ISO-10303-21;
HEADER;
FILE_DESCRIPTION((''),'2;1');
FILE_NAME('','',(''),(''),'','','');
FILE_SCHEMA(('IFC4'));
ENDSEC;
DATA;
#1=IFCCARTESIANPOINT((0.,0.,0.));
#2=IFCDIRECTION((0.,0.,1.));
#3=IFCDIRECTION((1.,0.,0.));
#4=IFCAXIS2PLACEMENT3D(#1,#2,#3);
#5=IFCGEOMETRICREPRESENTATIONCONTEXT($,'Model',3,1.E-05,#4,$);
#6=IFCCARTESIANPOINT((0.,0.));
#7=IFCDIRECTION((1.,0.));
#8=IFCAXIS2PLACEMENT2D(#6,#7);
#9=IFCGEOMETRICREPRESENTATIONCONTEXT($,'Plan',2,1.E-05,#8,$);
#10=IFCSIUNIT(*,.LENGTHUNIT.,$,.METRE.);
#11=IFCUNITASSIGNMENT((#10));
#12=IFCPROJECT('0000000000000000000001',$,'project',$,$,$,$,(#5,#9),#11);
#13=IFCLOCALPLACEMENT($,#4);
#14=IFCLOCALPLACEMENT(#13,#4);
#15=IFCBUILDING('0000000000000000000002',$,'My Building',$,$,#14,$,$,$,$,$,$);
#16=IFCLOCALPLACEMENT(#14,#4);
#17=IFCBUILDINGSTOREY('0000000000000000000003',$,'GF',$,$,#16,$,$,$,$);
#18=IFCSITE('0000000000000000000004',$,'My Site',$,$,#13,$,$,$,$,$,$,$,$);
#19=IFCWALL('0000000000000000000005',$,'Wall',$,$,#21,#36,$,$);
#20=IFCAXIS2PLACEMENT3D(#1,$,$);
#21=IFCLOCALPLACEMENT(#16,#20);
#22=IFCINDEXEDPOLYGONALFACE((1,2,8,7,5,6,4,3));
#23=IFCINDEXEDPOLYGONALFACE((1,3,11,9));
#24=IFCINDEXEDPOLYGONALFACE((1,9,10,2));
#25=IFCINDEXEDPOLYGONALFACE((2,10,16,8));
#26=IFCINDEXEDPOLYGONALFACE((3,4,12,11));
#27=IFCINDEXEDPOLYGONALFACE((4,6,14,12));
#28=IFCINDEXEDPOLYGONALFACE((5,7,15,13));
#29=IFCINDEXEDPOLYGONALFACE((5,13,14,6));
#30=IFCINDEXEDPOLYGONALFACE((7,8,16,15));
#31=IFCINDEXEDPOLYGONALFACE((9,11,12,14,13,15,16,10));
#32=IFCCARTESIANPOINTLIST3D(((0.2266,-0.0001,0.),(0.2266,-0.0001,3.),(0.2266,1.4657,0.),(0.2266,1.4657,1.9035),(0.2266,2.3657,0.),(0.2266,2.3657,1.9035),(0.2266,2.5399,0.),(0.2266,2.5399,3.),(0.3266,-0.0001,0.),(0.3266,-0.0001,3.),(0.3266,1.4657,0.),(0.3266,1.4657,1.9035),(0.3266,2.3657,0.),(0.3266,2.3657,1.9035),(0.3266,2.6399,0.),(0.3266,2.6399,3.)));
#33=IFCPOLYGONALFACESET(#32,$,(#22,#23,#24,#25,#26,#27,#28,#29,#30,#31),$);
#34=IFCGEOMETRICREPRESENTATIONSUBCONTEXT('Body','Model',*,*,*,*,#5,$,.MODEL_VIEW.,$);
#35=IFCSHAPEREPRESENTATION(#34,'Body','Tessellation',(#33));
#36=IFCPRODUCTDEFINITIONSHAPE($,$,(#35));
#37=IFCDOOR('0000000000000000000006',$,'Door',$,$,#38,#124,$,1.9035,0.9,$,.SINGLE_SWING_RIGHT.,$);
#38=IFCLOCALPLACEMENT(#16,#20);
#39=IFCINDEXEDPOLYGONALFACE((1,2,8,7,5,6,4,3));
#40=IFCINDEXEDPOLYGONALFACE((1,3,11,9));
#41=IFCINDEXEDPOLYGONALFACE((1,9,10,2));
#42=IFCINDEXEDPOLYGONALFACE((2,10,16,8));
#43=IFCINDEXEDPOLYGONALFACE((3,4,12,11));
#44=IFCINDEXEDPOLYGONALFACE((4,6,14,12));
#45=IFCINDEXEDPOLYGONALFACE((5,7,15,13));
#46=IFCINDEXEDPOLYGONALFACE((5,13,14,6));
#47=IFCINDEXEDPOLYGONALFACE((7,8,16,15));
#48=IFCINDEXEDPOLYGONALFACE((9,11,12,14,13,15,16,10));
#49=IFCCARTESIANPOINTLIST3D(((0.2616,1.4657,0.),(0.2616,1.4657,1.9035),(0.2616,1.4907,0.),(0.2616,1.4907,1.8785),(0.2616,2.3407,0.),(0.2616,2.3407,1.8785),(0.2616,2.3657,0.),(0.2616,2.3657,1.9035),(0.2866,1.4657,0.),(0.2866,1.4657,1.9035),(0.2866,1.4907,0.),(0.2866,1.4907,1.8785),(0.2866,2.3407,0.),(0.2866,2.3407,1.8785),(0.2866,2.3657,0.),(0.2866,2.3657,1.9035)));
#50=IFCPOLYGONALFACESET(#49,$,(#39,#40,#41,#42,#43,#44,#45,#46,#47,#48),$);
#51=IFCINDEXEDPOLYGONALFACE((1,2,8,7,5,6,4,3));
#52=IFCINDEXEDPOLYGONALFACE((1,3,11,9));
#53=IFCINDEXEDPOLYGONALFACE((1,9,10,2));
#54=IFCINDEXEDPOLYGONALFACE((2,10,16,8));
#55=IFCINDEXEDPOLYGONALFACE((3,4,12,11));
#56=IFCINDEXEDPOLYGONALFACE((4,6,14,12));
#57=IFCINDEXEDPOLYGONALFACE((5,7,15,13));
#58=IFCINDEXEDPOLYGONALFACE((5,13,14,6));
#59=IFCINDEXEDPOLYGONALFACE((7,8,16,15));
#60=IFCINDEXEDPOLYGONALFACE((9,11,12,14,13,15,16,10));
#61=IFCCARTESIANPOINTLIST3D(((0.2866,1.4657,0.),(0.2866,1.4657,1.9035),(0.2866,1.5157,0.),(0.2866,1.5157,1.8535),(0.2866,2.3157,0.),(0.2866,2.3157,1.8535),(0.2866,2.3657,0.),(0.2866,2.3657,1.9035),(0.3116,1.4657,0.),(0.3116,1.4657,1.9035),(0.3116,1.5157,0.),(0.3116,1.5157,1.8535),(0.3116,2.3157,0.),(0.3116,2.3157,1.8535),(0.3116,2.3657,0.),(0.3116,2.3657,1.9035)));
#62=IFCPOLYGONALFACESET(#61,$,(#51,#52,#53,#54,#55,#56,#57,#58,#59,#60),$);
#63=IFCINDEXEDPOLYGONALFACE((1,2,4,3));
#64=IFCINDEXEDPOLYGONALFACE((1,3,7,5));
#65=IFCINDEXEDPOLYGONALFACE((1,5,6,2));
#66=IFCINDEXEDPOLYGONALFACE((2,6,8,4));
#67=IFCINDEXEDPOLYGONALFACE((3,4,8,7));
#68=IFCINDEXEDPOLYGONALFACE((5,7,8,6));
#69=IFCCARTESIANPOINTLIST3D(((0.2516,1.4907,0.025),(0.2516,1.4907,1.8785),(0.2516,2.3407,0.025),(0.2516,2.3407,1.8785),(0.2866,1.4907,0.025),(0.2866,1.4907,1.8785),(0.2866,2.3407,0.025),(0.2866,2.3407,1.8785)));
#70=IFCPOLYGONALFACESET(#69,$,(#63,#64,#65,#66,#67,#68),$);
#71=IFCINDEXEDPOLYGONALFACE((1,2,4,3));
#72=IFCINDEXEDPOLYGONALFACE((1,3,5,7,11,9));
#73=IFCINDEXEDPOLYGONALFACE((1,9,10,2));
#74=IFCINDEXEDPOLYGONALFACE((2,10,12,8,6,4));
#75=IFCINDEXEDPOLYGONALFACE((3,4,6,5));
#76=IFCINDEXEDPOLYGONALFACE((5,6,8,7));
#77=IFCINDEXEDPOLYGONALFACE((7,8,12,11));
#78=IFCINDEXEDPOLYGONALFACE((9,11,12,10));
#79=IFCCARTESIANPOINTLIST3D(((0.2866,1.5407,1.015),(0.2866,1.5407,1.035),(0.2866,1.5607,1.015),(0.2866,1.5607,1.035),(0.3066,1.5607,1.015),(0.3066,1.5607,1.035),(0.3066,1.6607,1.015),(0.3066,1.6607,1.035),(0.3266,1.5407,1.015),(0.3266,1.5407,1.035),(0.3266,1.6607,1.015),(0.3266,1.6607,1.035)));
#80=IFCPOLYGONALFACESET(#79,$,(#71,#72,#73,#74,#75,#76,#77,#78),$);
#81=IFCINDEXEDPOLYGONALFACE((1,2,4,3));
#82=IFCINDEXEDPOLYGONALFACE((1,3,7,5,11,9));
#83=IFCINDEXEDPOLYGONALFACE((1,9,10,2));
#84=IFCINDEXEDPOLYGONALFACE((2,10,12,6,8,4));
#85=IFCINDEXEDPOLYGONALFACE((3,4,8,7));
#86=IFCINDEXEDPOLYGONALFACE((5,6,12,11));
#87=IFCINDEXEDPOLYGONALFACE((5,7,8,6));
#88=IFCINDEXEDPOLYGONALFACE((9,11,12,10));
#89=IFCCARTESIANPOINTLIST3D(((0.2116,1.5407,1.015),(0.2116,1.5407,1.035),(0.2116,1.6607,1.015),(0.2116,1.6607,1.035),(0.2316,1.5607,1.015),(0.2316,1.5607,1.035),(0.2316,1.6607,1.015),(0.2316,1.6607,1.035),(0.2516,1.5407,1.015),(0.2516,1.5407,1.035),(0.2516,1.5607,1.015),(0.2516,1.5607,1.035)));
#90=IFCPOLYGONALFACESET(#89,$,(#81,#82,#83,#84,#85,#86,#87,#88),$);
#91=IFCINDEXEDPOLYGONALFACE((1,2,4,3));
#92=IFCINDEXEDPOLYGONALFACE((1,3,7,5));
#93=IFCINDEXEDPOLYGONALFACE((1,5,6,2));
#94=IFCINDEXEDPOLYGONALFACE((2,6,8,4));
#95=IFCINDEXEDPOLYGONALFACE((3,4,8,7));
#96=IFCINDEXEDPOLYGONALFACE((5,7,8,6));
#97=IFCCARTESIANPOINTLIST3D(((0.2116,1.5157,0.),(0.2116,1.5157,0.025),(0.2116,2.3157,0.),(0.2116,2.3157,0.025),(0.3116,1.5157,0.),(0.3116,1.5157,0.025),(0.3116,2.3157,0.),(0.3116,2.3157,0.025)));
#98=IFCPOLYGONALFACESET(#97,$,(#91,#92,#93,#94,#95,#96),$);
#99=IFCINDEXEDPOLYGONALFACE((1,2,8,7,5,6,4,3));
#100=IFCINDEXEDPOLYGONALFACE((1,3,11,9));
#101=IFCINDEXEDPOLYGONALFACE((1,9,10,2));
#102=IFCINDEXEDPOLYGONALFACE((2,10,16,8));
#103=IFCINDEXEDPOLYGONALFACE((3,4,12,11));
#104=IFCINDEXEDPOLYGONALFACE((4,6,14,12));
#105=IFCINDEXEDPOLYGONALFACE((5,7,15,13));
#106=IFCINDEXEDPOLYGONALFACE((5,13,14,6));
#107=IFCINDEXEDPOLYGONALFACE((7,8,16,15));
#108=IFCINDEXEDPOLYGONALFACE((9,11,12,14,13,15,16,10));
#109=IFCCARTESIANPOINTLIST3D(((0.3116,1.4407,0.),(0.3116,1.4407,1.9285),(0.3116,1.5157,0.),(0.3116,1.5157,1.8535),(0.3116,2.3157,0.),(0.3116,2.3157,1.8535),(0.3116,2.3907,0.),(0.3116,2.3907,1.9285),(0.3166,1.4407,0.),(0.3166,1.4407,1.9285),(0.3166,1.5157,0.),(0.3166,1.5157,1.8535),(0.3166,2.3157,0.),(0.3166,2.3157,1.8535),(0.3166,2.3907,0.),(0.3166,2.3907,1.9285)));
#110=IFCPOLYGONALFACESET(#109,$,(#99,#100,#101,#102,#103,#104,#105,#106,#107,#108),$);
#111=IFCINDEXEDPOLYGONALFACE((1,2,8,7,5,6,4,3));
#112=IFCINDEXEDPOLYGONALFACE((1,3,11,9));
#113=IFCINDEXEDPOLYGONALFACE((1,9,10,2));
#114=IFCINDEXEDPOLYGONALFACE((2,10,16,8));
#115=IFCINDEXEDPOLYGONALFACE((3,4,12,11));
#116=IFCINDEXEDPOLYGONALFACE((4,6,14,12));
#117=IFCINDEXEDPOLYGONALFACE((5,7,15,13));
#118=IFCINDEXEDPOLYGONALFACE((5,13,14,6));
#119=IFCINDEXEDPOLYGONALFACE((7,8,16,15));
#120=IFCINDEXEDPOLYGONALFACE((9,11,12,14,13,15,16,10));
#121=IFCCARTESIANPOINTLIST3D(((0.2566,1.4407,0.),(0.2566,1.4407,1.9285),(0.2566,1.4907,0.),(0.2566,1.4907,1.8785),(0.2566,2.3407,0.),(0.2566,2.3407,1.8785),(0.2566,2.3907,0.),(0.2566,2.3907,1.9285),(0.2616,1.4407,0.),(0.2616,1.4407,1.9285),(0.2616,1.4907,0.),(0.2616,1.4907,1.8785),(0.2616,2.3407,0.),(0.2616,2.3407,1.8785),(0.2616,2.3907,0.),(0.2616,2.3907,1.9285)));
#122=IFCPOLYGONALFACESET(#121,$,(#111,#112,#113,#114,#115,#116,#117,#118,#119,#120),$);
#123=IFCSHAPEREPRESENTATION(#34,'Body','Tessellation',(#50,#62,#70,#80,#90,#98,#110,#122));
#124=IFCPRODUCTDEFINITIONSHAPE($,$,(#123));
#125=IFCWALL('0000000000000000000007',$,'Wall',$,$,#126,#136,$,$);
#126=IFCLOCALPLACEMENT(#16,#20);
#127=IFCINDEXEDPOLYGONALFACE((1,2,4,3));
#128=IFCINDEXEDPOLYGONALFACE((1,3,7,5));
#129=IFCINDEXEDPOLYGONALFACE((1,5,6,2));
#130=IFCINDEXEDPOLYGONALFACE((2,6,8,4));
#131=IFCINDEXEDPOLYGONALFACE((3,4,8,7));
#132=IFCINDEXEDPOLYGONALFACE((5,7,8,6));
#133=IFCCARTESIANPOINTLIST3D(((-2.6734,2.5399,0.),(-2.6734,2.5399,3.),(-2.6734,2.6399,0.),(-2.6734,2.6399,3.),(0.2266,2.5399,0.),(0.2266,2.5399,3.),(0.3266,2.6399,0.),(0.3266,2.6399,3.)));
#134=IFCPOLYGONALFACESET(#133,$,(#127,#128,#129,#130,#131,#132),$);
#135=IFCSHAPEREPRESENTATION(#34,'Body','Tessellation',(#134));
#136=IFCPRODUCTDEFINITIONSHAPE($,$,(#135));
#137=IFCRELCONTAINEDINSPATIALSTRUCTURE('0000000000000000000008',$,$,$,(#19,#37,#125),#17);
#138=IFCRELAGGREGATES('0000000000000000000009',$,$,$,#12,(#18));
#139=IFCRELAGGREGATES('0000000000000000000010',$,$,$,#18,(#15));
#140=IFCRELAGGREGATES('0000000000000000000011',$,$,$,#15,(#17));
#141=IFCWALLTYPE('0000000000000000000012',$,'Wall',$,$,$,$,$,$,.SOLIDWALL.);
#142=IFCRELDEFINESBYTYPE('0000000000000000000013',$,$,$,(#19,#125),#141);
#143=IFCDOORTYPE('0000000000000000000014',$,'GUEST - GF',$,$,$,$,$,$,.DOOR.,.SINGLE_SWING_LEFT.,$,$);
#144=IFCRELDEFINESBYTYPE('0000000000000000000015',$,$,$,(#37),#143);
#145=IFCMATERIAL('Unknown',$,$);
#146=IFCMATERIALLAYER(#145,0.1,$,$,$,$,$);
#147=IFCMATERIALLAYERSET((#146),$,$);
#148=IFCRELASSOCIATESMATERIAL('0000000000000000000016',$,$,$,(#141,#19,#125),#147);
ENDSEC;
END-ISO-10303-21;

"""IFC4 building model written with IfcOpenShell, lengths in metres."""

from ifc_helpers import new_model, entity, si_unit, frame, origin_with_axes, origin_2d_with_axis, place, context, subcontext, project, spatial, line, indexed_curve, outline, extrude, shape, source, transform, mapped, material, layer, layer_set, layer_usage, type_object, type_shapes, element, fill, save


model = new_model("IFC4")

# Units and contexts
model_context = context("Model", 3, precision=1e-05, world=origin_with_axes())
plan_context = context("Plan", 2, precision=1e-05, world=origin_2d_with_axis())
body_context_1 = subcontext(model_context, "Body", "Model", "MODEL_VIEW")
body_context_2 = subcontext(plan_context, "Body", "Plan", "PLAN_VIEW")
ifc_project = project(units=[si_unit("LENGTHUNIT", "METRE")], contexts=[model_context, plan_context])

# Site, building, storey
site_placement = place(None, origin_with_axes())
site = spatial("IfcSite", under=ifc_project, at=site_placement, Name="My Site")
building_placement = place(site_placement, origin_with_axes())
building = spatial("IfcBuilding", under=site, at=building_placement, Name="My Building")
storey_placement = place(building_placement, origin_with_axes())
storey = spatial("IfcBuildingStorey", under=building, at=storey_placement, Name="GF")

# Shared definitions
ifc_material = material(Name="Unknown")

# Shared definitions
ifc_layer_1 = layer(ifc_material, 0.1)
ifc_layer_set_1 = layer_set([ifc_layer_1])
wall_type = type_object("IfcWallType", Name="Wall", PredefinedType="SOLIDWALL", material=ifc_layer_set_1)

# Wall, opening, door
ifc_layer_usage_1 = layer_usage(ifc_layer_set_1, "AXIS2", "POSITIVE", 0.0)
wall_1_placement = place(storey_placement, frame((0.3266, -0.0001, 0.0), z_axis=(0.0, 0.0, 1.0), x_axis=(0.0, 1.0, 0.0)))
wall_1 = element("IfcWall", 1, at=wall_1_placement, inside=storey, type_object=wall_type, material=ifc_layer_usage_1, Name="Wall", context=body_context_1, shape_type="SweptSolid", body=[
    extrude(outline(indexed_curve([(0.0, 0.0), (0.0, 0.1), (2.54, 0.1), (2.64, 0.0)], segments=[line(1, 2, 3, 4, 1)])), origin_with_axes(), (0.0, 0.0, 1.0), 3.0),
])
shared_shape_1 = source(origin_with_axes(), body_context_1, "Body", "SweptSolid", [
    extrude(outline(indexed_curve([(0.0, 0.0), (0.9, 0.0), (0.9, 1.9035), (0.0, 1.9035)], segments=[line(1, 2, 3, 4, 1)])), frame((0.0, -0.6, 0.0), z_axis=(0.0, -1.0, 0.0), x_axis=(1.0, 0.0, 0.0)), (0.0, 0.0, -1.0), 1.2),
])
opening_1_placement = place(wall_1_placement, frame((1.4658, 0.015, 0.0), z_axis=(0.0, 0.0, 1.0), x_axis=(1.0, 0.0, 0.0)))
opening_1 = element("IfcOpeningElement", 2, at=opening_1_placement, cuts=wall_1, PredefinedType="OPENING", context=body_context_1, shape_type="MappedRepresentation", body=[
    mapped(shared_shape_1, transform((0.0, 0.0, 0.0), x_axis=(1.0, 0.0, 0.0), y_axis=(0.0, 1.0, 0.0), z_axis=(0.0, 0.0, 1.0), scale=1.0)),
])
door_type_1 = type_object("IfcDoorType", Name="GUEST - GF", OperationType="SINGLE_SWING_LEFT", PredefinedType="DOOR")
shared_shape_2 = source(origin_with_axes(), body_context_1, "Body", "SweptSolid", [
    extrude(outline(indexed_curve([(0.0, 0.0), (0.0, 1.9035), (0.9, 1.9035), (0.9, 0.0), (0.875, 0.0), (0.875, 1.8785), (0.025, 1.8785), (0.025, 0.0)], segments=[line(1, 2, 3, 4, 5, 6, 7, 8, 1)])), frame((0.0, 0.025, 0.0), z_axis=(0.0, -1.0, 0.0), x_axis=(1.0, 0.0, 0.0)), (0.0, 0.0, -1.0), 0.025),
    extrude(outline(indexed_curve([(0.0, 0.0), (0.0, 1.9035), (0.9, 1.9035), (0.9, 0.0), (0.85, 0.0), (0.85, 1.8535), (0.05, 1.8535), (0.05, 0.0)], segments=[line(1, 2, 3, 4, 5, 6, 7, 8, 1)])), frame((0.0, 0.0, 0.0), z_axis=(0.0, -1.0, 0.0), x_axis=(1.0, 0.0, 0.0)), (0.0, 0.0, -1.0), 0.025),
    extrude(outline(indexed_curve([(0.0, 0.0), (0.85, 0.0), (0.85, 0.035), (0.0, 0.035)], segments=[line(1, 2, 3, 4, 1)])), frame((0.025, 0.025, 0.025), z_axis=(0.0, 0.0, 1.0), x_axis=(1.0, 0.0, 0.0)), (0.0, 0.0, 1.0), 1.8535),
    extrude(outline(indexed_curve([(0.0, 0.0), (0.0, -0.04), (0.12, -0.04), (0.12, -0.02), (0.02, -0.02), (0.02, 0.0)], segments=[line(1, 2, 3, 4, 5, 6, 1)])), frame((0.075, 0.025, 1.015), z_axis=(0.0, 0.0, 1.0), x_axis=(1.0, 0.0, 0.0)), (0.0, 0.0, 1.0), 0.02),
    extrude(outline(indexed_curve([(0.0, 0.0), (0.0, 0.04), (0.12, 0.04), (0.12, 0.02), (0.02, 0.02), (0.02, 0.0)], segments=[line(1, 2, 3, 4, 5, 6, 1)])), frame((0.075, 0.06, 1.015), z_axis=(0.0, 0.0, 1.0), x_axis=(1.0, 0.0, 0.0)), (0.0, 0.0, 1.0), 0.02),
    extrude(outline(indexed_curve([(0.0, 0.0), (0.8, 0.0), (0.8, 0.1), (0.0, 0.1)], segments=[line(1, 2, 3, 4, 1)])), frame((0.05, 0.0, 0.0), z_axis=(0.0, 0.0, 1.0), x_axis=(1.0, 0.0, 0.0)), (0.0, 0.0, 1.0), 0.025),
    extrude(outline(indexed_curve([(0.0, 0.0), (0.0, 1.9285), (0.95, 1.9285), (0.95, 0.0), (0.875, 0.0), (0.875, 1.8535), (0.075, 1.8535), (0.075, 0.0)], segments=[line(1, 2, 3, 4, 5, 6, 7, 8, 1)])), frame((-0.025, -0.005, 0.0), z_axis=(0.0, -1.0, 0.0), x_axis=(1.0, 0.0, 0.0)), (0.0, 0.0, -1.0), 0.005),
    extrude(outline(indexed_curve([(0.0, 0.0), (0.0, 1.9285), (0.95, 1.9285), (0.95, 0.0), (0.9, 0.0), (0.9, 1.8785), (0.05, 1.8785), (0.05, 0.0)], segments=[line(1, 2, 3, 4, 5, 6, 7, 8, 1)])), frame((-0.025, 0.05, 0.0), z_axis=(0.0, -1.0, 0.0), x_axis=(1.0, 0.0, 0.0)), (0.0, 0.0, -1.0), 0.005),
])
shared_shape_3 = source(origin_with_axes(), body_context_2, "Body", "Curve2D", [
    entity("IfcIndexedPolyCurve", entity("IfcCartesianPointList2D", [[0.0, 0.0], [0.0, 0.05], [0.025, 0.05], [0.025, 0.025], [0.05, 0.025], [0.05, 0.0]]), [entity("IfcLineIndex", [1, 2, 3, 4, 5, 6, 1])]),
    entity("IfcIndexedPolyCurve", entity("IfcCartesianPointList2D", [[0.9, 0.0], [0.9, 0.05], [0.875, 0.05], [0.875, 0.025], [0.85, 0.025], [0.85, 0.0]]), [entity("IfcLineIndex", [1, 2, 3, 4, 5, 6, 1])]),
    entity("IfcTrimmedCurve", entity("IfcEllipse", entity("IfcAxis2Placement2D", entity("IfcCartesianPoint", [0.84, 0.05]), entity("IfcDirection", [1.0, 0.0])), 0.815, 0.85), [entity("IfcCartesianPoint", [0.84, 0.9])], [entity("IfcCartesianPoint", [0.025, 0.05])], True, "CARTESIAN"),
    entity("IfcIndexedPolyCurve", entity("IfcCartesianPointList2D", [[0.875, 0.05], [0.84, 0.05], [0.84, 0.9], [0.875, 0.9]]), [entity("IfcLineIndex", [1, 2, 3, 4, 1])]),
])
type_shapes(door_type_1, [shared_shape_2, shared_shape_3])
door_1_placement = place(opening_1_placement, frame((0.0, 0.0, 0.0), z_axis=(0.0, 0.0, 1.0), x_axis=(1.0, 0.0, 0.0)))
door_1 = element("IfcDoor", 3, at=door_1_placement, inside=storey, type_object=door_type_1, Name="Door", OperationType="SINGLE_SWING_RIGHT", OverallHeight=1.9035, OverallWidth=0.9, shapes=[
    shape(body_context_1, "Body", "MappedRepresentation", [mapped(shared_shape_2, transform((0.0, 0.0, 0.0), x_axis=(1.0, 0.0, 0.0), y_axis=(0.0, 1.0, 0.0), z_axis=(0.0, 0.0, 1.0), scale=1.0))]),
    shape(body_context_2, "Body", "MappedRepresentation", [mapped(shared_shape_3, transform((0.0, 0.0, 0.0), x_axis=(1.0, 0.0, 0.0), y_axis=(0.0, 1.0, 0.0), z_axis=(0.0, 0.0, 1.0), scale=1.0))]),
])
fill(opening_1, door_1)

# Wall
ifc_layer_usage_2 = layer_usage(ifc_layer_set_1, "AXIS2", "POSITIVE", 0.0)
wall_2_placement = place(storey_placement, frame((0.3266, 2.6399, 0.0), z_axis=(0.0, 0.0, 1.0), x_axis=(-1.0, 0.0, 0.0)))
element("IfcWall", 4, at=wall_2_placement, inside=storey, type_object=wall_type, material=ifc_layer_usage_2, Name="Wall", context=body_context_1, shape_type="SweptSolid", body=[
    extrude(outline(indexed_curve([(0.0, 0.0), (0.1, 0.1), (3.0, 0.1), (3.0, 0.0)], segments=[line(1, 2, 3, 4, 1)])), origin_with_axes(), (0.0, 0.0, 1.0), 3.0),
])

save(model, "model.ifc")
